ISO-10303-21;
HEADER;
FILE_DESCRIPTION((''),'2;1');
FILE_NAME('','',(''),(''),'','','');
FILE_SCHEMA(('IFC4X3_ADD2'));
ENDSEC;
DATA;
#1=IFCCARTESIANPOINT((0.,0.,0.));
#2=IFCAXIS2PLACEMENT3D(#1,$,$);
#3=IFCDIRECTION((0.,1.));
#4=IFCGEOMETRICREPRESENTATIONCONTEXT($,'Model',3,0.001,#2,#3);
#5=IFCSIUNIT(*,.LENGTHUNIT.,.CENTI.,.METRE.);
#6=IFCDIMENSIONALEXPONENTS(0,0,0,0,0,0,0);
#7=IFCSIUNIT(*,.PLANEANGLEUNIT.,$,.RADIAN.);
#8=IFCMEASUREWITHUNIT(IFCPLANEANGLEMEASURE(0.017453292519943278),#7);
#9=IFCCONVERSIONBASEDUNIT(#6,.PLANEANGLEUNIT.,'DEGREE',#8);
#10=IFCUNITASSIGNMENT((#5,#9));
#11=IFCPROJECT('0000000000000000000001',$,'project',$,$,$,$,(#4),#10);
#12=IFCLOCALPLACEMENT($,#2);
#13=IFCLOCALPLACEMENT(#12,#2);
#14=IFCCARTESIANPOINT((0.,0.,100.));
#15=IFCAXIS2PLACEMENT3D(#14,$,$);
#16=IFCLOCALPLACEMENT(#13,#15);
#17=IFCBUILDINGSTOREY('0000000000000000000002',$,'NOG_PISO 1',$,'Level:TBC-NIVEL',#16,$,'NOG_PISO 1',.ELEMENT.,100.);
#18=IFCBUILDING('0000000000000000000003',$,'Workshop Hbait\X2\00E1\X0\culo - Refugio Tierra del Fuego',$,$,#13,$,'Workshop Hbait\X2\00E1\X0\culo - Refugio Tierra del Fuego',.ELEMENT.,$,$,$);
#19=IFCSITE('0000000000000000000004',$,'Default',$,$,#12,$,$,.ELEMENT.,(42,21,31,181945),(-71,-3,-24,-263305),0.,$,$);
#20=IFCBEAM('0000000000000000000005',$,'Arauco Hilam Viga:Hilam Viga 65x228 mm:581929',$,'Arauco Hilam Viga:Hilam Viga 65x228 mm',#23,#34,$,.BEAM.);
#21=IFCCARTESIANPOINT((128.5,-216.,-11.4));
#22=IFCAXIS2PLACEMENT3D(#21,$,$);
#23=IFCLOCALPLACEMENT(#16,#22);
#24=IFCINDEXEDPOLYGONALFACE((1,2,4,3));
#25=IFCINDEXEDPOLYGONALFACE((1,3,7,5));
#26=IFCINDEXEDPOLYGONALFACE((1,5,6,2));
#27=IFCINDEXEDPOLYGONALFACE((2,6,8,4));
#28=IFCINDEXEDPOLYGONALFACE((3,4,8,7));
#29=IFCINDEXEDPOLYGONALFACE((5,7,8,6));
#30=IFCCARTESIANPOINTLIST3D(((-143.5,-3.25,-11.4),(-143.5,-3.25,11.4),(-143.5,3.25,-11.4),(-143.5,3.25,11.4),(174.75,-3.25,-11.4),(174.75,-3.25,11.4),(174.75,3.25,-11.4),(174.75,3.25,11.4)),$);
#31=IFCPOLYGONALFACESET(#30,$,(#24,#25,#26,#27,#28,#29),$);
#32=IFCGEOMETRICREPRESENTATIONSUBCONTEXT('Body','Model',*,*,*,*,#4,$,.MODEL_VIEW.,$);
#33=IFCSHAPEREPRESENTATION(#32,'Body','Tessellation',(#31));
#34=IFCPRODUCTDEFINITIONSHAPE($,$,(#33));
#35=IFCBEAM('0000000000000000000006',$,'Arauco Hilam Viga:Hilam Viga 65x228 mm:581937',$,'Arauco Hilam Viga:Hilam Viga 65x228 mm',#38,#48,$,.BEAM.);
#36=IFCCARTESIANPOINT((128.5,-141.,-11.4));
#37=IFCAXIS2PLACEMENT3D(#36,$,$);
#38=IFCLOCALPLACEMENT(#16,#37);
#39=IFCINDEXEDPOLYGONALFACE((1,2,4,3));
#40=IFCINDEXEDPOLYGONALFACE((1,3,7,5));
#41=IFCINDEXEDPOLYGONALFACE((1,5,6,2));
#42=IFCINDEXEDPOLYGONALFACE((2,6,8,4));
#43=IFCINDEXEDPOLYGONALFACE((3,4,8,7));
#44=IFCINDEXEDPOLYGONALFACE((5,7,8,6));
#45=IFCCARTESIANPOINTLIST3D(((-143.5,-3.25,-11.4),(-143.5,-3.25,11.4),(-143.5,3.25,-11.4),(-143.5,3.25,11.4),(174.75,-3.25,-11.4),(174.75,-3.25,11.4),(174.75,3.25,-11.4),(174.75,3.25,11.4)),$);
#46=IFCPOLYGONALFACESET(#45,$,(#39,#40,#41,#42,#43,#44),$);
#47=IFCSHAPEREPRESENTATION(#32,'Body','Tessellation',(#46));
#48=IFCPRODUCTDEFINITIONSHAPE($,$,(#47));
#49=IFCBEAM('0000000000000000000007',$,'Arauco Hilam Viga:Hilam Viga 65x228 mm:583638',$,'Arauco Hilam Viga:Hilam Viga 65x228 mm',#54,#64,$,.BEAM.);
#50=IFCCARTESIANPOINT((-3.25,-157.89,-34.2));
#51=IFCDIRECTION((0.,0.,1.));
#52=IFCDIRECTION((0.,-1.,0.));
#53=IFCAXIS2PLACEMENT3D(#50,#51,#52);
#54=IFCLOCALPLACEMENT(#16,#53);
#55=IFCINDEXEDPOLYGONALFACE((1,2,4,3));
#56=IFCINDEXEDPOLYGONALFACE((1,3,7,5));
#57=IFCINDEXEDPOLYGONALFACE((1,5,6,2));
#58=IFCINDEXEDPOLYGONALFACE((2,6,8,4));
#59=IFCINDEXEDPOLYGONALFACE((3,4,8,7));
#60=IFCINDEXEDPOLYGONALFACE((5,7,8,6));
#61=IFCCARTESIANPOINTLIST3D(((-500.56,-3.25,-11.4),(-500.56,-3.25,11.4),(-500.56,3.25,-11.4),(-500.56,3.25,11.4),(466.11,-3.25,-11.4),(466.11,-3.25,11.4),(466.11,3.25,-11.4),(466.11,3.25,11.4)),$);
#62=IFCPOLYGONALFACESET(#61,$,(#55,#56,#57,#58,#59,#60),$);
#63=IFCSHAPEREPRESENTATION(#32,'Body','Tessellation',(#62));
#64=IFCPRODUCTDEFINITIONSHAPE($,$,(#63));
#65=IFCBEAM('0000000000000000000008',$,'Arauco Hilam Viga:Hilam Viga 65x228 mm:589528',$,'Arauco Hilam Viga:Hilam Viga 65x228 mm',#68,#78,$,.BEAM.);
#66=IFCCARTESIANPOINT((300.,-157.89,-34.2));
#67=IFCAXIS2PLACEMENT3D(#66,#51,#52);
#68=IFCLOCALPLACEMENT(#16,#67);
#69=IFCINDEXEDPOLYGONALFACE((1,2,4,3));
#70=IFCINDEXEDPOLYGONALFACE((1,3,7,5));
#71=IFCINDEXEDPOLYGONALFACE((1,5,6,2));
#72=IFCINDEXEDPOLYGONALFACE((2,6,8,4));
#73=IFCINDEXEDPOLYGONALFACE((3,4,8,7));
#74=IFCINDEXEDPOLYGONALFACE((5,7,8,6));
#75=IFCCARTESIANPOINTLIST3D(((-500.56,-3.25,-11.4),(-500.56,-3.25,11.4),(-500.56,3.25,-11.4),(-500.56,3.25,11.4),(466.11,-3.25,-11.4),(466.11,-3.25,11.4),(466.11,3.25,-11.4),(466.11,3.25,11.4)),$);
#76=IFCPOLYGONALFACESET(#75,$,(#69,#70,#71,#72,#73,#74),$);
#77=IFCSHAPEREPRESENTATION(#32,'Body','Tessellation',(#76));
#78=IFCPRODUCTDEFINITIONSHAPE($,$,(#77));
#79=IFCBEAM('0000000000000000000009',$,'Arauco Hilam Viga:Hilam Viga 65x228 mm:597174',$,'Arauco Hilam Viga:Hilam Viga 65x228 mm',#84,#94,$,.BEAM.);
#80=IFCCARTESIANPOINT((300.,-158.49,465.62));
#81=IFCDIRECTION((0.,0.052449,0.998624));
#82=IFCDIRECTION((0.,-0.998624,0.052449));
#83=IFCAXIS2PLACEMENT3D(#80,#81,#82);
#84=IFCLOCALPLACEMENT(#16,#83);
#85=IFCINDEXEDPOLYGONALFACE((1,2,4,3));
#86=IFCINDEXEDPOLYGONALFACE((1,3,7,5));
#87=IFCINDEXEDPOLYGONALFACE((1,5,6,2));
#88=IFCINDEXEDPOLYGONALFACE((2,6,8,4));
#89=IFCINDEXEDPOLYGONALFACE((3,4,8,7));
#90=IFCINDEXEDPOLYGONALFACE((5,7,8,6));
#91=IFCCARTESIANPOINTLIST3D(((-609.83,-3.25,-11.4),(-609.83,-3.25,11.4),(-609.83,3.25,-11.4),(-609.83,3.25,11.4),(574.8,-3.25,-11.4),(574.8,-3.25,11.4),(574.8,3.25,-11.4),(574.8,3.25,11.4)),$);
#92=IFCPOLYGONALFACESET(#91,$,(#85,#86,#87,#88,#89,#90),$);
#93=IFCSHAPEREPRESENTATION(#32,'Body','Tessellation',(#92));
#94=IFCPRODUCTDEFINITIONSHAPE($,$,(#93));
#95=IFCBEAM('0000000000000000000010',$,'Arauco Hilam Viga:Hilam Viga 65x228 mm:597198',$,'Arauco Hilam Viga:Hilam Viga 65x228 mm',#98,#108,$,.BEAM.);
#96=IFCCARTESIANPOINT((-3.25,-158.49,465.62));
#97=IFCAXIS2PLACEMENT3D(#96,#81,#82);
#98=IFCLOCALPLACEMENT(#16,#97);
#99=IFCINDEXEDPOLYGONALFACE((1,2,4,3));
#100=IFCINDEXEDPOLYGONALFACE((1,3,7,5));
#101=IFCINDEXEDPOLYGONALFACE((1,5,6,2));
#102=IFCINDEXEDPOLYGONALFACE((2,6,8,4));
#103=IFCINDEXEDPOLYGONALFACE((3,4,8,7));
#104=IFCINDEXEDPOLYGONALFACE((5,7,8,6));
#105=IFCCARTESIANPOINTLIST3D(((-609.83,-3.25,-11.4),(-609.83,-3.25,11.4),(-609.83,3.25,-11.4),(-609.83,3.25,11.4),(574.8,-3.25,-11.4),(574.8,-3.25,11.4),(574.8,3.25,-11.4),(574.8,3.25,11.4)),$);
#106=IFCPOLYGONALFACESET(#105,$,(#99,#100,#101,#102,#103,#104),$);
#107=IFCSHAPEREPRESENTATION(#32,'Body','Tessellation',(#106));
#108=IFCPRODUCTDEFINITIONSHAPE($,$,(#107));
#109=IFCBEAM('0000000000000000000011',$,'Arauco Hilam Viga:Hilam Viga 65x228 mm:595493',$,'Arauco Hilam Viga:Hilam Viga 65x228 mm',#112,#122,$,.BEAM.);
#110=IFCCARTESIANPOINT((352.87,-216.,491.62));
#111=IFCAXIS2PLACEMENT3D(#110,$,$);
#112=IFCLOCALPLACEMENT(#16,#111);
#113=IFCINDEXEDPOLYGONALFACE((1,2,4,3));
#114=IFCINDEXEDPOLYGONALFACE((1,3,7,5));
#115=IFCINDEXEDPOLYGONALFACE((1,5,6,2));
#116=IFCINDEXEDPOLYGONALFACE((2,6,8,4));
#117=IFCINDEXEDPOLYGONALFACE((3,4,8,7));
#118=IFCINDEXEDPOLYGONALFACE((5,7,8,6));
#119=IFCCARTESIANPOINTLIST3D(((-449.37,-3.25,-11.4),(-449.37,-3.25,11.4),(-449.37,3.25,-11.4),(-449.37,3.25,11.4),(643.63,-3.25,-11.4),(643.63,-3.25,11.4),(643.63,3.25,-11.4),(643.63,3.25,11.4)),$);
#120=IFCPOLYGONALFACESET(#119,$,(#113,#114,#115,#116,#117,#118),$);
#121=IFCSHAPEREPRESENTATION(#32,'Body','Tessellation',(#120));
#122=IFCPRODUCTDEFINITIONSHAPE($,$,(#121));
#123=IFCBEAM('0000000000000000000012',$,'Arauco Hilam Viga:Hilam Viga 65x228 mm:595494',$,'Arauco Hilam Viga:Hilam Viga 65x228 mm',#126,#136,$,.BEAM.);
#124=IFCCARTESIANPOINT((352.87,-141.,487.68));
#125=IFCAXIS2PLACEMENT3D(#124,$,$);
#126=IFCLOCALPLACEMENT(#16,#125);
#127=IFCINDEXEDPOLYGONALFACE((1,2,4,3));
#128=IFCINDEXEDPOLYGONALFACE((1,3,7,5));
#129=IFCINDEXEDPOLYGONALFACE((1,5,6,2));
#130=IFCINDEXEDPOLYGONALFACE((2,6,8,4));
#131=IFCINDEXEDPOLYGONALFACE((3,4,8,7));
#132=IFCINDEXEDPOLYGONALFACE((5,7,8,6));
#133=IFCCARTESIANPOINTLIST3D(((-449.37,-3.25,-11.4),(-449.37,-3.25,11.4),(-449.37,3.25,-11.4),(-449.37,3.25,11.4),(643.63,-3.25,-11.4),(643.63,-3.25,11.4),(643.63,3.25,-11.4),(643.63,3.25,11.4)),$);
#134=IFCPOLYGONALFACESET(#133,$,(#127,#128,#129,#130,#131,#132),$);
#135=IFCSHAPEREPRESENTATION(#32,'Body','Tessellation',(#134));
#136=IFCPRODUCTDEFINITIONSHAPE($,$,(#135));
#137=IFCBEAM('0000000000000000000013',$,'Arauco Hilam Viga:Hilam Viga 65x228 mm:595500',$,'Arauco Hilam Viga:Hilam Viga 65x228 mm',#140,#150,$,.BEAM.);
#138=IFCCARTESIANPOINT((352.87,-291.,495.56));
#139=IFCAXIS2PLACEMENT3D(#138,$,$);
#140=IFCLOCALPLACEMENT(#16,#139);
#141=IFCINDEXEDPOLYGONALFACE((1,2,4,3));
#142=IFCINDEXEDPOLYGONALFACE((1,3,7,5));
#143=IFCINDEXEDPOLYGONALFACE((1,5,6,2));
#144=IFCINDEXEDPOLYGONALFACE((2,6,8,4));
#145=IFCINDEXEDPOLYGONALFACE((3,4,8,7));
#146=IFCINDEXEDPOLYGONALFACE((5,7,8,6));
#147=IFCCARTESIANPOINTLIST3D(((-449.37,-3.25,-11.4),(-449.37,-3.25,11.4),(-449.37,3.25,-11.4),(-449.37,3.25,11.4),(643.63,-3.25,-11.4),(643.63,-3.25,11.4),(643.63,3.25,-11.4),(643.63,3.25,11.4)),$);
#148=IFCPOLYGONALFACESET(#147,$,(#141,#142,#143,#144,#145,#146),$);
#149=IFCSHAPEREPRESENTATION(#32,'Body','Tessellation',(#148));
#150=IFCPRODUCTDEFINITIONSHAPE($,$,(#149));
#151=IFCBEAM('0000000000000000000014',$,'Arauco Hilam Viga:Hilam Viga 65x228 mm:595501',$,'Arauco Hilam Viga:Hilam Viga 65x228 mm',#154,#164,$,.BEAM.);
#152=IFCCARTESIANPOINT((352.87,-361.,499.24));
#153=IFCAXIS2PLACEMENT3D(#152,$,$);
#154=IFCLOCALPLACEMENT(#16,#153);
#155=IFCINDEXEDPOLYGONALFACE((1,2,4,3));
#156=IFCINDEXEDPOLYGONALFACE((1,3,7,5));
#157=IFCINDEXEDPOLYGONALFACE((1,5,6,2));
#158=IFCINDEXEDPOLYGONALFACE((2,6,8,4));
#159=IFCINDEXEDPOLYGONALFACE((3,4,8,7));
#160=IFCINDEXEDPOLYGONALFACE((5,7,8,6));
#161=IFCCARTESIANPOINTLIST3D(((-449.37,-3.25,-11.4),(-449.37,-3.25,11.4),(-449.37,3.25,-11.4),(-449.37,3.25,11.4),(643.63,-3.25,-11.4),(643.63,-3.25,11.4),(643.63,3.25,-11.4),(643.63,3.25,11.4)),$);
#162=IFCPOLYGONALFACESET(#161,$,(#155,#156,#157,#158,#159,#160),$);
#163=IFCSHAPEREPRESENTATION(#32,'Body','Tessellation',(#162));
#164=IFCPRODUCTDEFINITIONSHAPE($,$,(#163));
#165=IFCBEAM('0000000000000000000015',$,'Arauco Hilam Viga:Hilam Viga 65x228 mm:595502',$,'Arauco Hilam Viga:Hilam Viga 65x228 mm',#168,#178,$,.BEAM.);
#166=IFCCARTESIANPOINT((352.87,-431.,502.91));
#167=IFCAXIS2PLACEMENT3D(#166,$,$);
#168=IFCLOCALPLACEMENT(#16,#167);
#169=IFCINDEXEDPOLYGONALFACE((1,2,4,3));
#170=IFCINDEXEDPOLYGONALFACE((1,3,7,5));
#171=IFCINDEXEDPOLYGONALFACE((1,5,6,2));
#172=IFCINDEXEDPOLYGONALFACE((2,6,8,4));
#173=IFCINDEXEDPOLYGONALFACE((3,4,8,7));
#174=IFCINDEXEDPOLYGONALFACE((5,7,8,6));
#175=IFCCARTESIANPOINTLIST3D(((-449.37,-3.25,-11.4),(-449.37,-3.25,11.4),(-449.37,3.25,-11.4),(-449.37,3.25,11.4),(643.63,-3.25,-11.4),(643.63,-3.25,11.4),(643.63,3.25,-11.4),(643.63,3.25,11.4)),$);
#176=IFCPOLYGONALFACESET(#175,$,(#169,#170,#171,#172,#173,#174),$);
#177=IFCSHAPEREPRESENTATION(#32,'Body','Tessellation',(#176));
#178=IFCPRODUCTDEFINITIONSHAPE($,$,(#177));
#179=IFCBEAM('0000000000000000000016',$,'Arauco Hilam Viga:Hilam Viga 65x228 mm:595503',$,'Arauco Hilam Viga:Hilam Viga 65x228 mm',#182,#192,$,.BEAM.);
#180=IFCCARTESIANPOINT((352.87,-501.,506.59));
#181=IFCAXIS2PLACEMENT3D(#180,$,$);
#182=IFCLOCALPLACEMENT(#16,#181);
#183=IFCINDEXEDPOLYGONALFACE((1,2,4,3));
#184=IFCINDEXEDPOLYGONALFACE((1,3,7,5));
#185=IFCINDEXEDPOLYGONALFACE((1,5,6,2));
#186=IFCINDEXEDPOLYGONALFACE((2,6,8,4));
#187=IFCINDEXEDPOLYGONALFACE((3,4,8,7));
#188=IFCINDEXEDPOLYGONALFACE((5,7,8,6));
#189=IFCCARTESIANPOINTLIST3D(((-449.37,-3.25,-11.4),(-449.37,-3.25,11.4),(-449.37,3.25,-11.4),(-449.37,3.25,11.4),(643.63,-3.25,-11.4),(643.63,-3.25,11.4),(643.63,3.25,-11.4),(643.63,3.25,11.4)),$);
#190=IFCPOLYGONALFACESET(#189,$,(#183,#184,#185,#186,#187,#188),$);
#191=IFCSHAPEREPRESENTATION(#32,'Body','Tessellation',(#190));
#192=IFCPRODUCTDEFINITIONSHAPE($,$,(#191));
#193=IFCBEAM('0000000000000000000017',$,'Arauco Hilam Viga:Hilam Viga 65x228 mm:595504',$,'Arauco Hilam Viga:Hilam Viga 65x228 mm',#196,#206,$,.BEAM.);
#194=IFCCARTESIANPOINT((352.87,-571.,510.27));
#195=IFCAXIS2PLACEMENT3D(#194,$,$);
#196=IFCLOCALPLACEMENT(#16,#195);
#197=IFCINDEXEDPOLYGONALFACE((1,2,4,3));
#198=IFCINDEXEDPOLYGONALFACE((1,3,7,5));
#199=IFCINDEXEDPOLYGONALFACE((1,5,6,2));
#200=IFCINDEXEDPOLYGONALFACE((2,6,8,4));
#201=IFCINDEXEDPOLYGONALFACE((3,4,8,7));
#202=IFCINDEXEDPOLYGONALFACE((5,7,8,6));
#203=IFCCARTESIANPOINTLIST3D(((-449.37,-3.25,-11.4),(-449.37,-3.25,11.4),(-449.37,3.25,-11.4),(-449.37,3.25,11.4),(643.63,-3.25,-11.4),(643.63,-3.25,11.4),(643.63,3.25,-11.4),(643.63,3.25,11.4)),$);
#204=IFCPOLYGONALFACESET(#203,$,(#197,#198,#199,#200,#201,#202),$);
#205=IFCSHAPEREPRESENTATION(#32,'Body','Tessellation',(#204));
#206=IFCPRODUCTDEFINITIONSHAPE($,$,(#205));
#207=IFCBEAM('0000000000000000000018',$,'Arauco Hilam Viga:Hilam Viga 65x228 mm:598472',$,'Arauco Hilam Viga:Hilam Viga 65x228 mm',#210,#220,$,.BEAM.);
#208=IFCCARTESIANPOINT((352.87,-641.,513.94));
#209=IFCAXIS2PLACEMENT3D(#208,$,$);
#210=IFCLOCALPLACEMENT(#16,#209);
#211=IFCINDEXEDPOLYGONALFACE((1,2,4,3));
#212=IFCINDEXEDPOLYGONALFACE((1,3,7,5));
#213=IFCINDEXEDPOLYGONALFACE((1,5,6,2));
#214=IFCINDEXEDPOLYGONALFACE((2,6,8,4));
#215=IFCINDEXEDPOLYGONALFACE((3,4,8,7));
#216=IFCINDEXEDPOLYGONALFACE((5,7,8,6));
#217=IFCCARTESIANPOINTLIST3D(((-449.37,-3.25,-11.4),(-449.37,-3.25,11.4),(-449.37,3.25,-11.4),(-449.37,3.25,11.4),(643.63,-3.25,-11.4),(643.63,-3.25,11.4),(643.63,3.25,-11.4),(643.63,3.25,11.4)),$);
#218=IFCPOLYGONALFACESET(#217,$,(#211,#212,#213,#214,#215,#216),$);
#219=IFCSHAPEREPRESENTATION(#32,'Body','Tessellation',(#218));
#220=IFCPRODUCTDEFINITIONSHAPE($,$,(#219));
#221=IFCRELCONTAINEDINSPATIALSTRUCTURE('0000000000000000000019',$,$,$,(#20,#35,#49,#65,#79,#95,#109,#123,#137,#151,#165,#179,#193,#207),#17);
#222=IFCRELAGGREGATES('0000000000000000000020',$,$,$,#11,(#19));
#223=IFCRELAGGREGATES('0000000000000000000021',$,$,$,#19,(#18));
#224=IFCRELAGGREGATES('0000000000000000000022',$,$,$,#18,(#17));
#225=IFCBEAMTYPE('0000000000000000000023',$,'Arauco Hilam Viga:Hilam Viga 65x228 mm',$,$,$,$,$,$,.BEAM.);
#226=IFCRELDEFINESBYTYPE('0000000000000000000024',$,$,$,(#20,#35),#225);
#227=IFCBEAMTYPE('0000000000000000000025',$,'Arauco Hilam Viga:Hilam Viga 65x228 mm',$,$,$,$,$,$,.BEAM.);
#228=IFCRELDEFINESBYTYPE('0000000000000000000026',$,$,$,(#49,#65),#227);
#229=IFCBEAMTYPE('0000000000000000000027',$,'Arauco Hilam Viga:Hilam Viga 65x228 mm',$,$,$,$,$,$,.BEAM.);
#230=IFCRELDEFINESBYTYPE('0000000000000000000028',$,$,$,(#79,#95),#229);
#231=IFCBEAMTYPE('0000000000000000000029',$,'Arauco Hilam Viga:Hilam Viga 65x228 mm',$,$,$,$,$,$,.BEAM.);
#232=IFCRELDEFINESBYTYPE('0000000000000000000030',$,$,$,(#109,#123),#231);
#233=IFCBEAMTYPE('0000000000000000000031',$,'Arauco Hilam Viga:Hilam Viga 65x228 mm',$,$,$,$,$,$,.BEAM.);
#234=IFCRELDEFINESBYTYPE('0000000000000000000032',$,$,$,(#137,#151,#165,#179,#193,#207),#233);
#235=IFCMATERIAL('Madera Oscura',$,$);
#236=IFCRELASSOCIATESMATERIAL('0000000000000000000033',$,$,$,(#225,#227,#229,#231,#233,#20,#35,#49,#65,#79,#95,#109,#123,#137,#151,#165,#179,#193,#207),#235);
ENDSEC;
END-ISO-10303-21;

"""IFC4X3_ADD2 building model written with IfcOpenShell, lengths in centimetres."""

from ifc_helpers import new_model, entity, si_unit, converted_unit, direction, frame, origin, origin_2d_with_axis, place, context, subcontext, project, spatial, rectangle, extrude, source, transform, mapped, material, material_profile, profile_set, profile_usage, type_object, type_shapes, element, save


model = new_model("IFC4X3_ADD2")

# Units and contexts
model_context = context("Model", 3, precision=0.001, world=origin(), true_north=direction((0.0, 1.0)))
body_context = subcontext(model_context, "Body", "Model", "MODEL_VIEW")
ifc_project = project(units=[si_unit("LENGTHUNIT", "METRE", prefix="CENTI"), converted_unit("PLANEANGLEUNIT", "DEGREE", entity("IfcPlaneAngleMeasure", 0.017453292519943278), si_unit("PLANEANGLEUNIT", "RADIAN"), dimensions=[0, 0, 0, 0, 0, 0, 0])], contexts=[model_context])

# Site, building, storey
site_placement = place(None, origin())
site = spatial("IfcSite", under=ifc_project, at=site_placement, Name="Default", CompositionType="ELEMENT", RefLatitude=(42, 21, 31, 181945), RefLongitude=(-71, -3, -24, -263305), RefElevation=0.0)
building_placement = place(site_placement, origin())
building = spatial("IfcBuilding", under=site, at=building_placement, Name="Workshop Hbaitáculo - Refugio Tierra del Fuego", LongName="Workshop Hbaitáculo - Refugio Tierra del Fuego", CompositionType="ELEMENT")
storey_placement = place(building_placement, frame((0.0, 0.0, 100.0)))
storey = spatial("IfcBuildingStorey", under=building, at=storey_placement, Name="NOG_PISO 1", ObjectType="Level:TBC-NIVEL", LongName="NOG_PISO 1", CompositionType="ELEMENT", Elevation=100.0)

# Beams
ifc_material_1 = material(Name="Madera Oscura")
ifc_material_profile_1 = material_profile(ifc_material_1, rectangle(XDim=930.0, YDim=6.5, at=origin_2d_with_axis()), Name="Hilam Viga 65x228 mm")
ifc_profile_set_1 = profile_set([ifc_material_profile_1], Name="Hilam Viga 65x228 mm")
ifc_profile_usage_1 = profile_usage(ifc_profile_set_1, cardinal=8)
beam_type_1 = type_object("IfcBeamType", Name="Arauco Hilam Viga:Hilam Viga 65x228 mm", PredefinedType="BEAM", material=ifc_profile_set_1)
shared_shape_1 = source(origin(), body_context, "Body", "SweptSolid", [
    extrude(rectangle(XDim=318.25, YDim=6.5, at=origin_2d_with_axis()), frame((15.63, 0.0, -11.4), z_axis=(0.0, 0.0, 1.0), x_axis=(-1.0, 0.0, 0.0)), (0.0, 0.0, 1.0), 22.8),
])
type_shapes(beam_type_1, [shared_shape_1])
for number, where, name in (
    (1, (128.5, -216.0, -11.4), "Arauco Hilam Viga:Hilam Viga 65x228 mm:581929"),
    (2, (128.5, -141.0, -11.4), "Arauco Hilam Viga:Hilam Viga 65x228 mm:581937"),
):
    element("IfcBeam", number, at=place(storey_placement, frame(where)), inside=storey, type_object=beam_type_1, material=ifc_profile_usage_1, Name=name, ObjectType="Arauco Hilam Viga:Hilam Viga 65x228 mm", PredefinedType="BEAM", context=body_context, shape_type="MappedRepresentation", body=[
        mapped(shared_shape_1, transform((0.0, 0.0, 0.0), scale=1.0)),
    ])
beam_type_2 = type_object("IfcBeamType", Name="Arauco Hilam Viga:Hilam Viga 65x228 mm", PredefinedType="BEAM", material=ifc_profile_set_1)
shared_shape_2 = source(origin(), body_context, "Body", "SweptSolid", [
    extrude(rectangle(XDim=966.67, YDim=6.5, at=origin_2d_with_axis()), frame((-17.23, 0.0, -11.4), z_axis=(0.0, 0.0, 1.0), x_axis=(-1.0, 0.0, 0.0)), (0.0, 0.0, 1.0), 22.8),
])
type_shapes(beam_type_2, [shared_shape_2])
for number, where, z_axis, x_axis, name in (
    (3, (-3.25, -157.89, -34.2), (0.0, 0.0, 1.0), (0.0, -1.0, 0.0), "Arauco Hilam Viga:Hilam Viga 65x228 mm:583638"),
    (4, (300.0, -157.89, -34.2), (0.0, 0.0, 1.0), (0.0, -1.0, 0.0), "Arauco Hilam Viga:Hilam Viga 65x228 mm:589528"),
):
    element("IfcBeam", number, at=place(storey_placement, frame(where, z_axis=z_axis, x_axis=x_axis)), inside=storey, type_object=beam_type_2, material=ifc_profile_usage_1, Name=name, ObjectType="Arauco Hilam Viga:Hilam Viga 65x228 mm", PredefinedType="BEAM", context=body_context, shape_type="MappedRepresentation", body=[
        mapped(shared_shape_2, transform((0.0, 0.0, 0.0), scale=1.0)),
    ])

# Beams
beam_type_3 = type_object("IfcBeamType", Name="Arauco Hilam Viga:Hilam Viga 65x228 mm", PredefinedType="BEAM", material=ifc_profile_set_1)
shared_shape_3 = source(origin(), body_context, "Body", "SweptSolid", [
    extrude(rectangle(XDim=6.5, YDim=1184.63, at=origin_2d_with_axis()), frame((-17.52, 0.0, -11.4), z_axis=(0.0, 0.0, 1.0), x_axis=(0.0, 1.0, 0.0)), (0.0, 0.0, 1.0), 22.8),
])
type_shapes(beam_type_3, [shared_shape_3])
for number, where, z_axis, x_axis, name in (
    (5, (300.0, -158.49, 465.62), (0.0, 0.052449, 0.998624), (0.0, -0.998624, 0.052449), "Arauco Hilam Viga:Hilam Viga 65x228 mm:597174"),
    (6, (-3.25, -158.49, 465.62), (0.0, 0.052449, 0.998624), (0.0, -0.998624, 0.052449), "Arauco Hilam Viga:Hilam Viga 65x228 mm:597198"),
):
    element("IfcBeam", number, at=place(storey_placement, frame(where, z_axis=z_axis, x_axis=x_axis)), inside=storey, type_object=beam_type_3, material=ifc_profile_usage_1, Name=name, ObjectType="Arauco Hilam Viga:Hilam Viga 65x228 mm", PredefinedType="BEAM", context=body_context, shape_type="MappedRepresentation", body=[
        mapped(shared_shape_3, transform((0.0, 0.0, 0.0), scale=1.0)),
    ])
beam_type_4 = type_object("IfcBeamType", Name="Arauco Hilam Viga:Hilam Viga 65x228 mm", PredefinedType="BEAM", material=ifc_profile_set_1)
shared_shape_4 = source(origin(), body_context, "Body", "SweptSolid", [
    extrude(rectangle(XDim=1093.0, YDim=6.5, at=origin_2d_with_axis()), frame((97.13, 0.0, -11.4), z_axis=(0.0, 0.0, 1.0), x_axis=(-1.0, 0.0, 0.0)), (0.0, 0.0, 1.0), 22.8),
])
type_shapes(beam_type_4, [shared_shape_4])
for number, where, name in (
    (7, (352.87, -216.0, 491.62), "Arauco Hilam Viga:Hilam Viga 65x228 mm:595493"),
    (8, (352.87, -141.0, 487.68), "Arauco Hilam Viga:Hilam Viga 65x228 mm:595494"),
):
    element("IfcBeam", number, at=place(storey_placement, frame(where)), inside=storey, type_object=beam_type_4, material=ifc_profile_usage_1, Name=name, ObjectType="Arauco Hilam Viga:Hilam Viga 65x228 mm", PredefinedType="BEAM", context=body_context, shape_type="MappedRepresentation", body=[
        mapped(shared_shape_4, transform((0.0, 0.0, 0.0), scale=1.0)),
    ])
beam_type_5 = type_object("IfcBeamType", Name="Arauco Hilam Viga:Hilam Viga 65x228 mm", PredefinedType="BEAM", material=ifc_profile_set_1)
shared_shape_5 = source(origin(), body_context, "Body", "SweptSolid", [
    extrude(rectangle(XDim=6.5, YDim=1093.0, at=origin_2d_with_axis()), frame((97.13, 0.0, -11.4), z_axis=(0.0, 0.0, 1.0), x_axis=(0.0, 1.0, 0.0)), (0.0, 0.0, 1.0), 22.8),
])
type_shapes(beam_type_5, [shared_shape_5])
for number, where, name in (
    (9, (352.87, -291.0, 495.56), "Arauco Hilam Viga:Hilam Viga 65x228 mm:595500"),
    (10, (352.87, -361.0, 499.24), "Arauco Hilam Viga:Hilam Viga 65x228 mm:595501"),
    (11, (352.87, -431.0, 502.91), "Arauco Hilam Viga:Hilam Viga 65x228 mm:595502"),
    (12, (352.87, -501.0, 506.59), "Arauco Hilam Viga:Hilam Viga 65x228 mm:595503"),
    (13, (352.87, -571.0, 510.27), "Arauco Hilam Viga:Hilam Viga 65x228 mm:595504"),
    (14, (352.87, -641.0, 513.94), "Arauco Hilam Viga:Hilam Viga 65x228 mm:598472"),
):
    element("IfcBeam", number, at=place(storey_placement, frame(where)), inside=storey, type_object=beam_type_5, material=ifc_profile_usage_1, Name=name, ObjectType="Arauco Hilam Viga:Hilam Viga 65x228 mm", PredefinedType="BEAM", context=body_context, shape_type="MappedRepresentation", body=[
        mapped(shared_shape_5, transform((0.0, 0.0, 0.0), scale=1.0)),
    ])

save(model, "model.ifc")
